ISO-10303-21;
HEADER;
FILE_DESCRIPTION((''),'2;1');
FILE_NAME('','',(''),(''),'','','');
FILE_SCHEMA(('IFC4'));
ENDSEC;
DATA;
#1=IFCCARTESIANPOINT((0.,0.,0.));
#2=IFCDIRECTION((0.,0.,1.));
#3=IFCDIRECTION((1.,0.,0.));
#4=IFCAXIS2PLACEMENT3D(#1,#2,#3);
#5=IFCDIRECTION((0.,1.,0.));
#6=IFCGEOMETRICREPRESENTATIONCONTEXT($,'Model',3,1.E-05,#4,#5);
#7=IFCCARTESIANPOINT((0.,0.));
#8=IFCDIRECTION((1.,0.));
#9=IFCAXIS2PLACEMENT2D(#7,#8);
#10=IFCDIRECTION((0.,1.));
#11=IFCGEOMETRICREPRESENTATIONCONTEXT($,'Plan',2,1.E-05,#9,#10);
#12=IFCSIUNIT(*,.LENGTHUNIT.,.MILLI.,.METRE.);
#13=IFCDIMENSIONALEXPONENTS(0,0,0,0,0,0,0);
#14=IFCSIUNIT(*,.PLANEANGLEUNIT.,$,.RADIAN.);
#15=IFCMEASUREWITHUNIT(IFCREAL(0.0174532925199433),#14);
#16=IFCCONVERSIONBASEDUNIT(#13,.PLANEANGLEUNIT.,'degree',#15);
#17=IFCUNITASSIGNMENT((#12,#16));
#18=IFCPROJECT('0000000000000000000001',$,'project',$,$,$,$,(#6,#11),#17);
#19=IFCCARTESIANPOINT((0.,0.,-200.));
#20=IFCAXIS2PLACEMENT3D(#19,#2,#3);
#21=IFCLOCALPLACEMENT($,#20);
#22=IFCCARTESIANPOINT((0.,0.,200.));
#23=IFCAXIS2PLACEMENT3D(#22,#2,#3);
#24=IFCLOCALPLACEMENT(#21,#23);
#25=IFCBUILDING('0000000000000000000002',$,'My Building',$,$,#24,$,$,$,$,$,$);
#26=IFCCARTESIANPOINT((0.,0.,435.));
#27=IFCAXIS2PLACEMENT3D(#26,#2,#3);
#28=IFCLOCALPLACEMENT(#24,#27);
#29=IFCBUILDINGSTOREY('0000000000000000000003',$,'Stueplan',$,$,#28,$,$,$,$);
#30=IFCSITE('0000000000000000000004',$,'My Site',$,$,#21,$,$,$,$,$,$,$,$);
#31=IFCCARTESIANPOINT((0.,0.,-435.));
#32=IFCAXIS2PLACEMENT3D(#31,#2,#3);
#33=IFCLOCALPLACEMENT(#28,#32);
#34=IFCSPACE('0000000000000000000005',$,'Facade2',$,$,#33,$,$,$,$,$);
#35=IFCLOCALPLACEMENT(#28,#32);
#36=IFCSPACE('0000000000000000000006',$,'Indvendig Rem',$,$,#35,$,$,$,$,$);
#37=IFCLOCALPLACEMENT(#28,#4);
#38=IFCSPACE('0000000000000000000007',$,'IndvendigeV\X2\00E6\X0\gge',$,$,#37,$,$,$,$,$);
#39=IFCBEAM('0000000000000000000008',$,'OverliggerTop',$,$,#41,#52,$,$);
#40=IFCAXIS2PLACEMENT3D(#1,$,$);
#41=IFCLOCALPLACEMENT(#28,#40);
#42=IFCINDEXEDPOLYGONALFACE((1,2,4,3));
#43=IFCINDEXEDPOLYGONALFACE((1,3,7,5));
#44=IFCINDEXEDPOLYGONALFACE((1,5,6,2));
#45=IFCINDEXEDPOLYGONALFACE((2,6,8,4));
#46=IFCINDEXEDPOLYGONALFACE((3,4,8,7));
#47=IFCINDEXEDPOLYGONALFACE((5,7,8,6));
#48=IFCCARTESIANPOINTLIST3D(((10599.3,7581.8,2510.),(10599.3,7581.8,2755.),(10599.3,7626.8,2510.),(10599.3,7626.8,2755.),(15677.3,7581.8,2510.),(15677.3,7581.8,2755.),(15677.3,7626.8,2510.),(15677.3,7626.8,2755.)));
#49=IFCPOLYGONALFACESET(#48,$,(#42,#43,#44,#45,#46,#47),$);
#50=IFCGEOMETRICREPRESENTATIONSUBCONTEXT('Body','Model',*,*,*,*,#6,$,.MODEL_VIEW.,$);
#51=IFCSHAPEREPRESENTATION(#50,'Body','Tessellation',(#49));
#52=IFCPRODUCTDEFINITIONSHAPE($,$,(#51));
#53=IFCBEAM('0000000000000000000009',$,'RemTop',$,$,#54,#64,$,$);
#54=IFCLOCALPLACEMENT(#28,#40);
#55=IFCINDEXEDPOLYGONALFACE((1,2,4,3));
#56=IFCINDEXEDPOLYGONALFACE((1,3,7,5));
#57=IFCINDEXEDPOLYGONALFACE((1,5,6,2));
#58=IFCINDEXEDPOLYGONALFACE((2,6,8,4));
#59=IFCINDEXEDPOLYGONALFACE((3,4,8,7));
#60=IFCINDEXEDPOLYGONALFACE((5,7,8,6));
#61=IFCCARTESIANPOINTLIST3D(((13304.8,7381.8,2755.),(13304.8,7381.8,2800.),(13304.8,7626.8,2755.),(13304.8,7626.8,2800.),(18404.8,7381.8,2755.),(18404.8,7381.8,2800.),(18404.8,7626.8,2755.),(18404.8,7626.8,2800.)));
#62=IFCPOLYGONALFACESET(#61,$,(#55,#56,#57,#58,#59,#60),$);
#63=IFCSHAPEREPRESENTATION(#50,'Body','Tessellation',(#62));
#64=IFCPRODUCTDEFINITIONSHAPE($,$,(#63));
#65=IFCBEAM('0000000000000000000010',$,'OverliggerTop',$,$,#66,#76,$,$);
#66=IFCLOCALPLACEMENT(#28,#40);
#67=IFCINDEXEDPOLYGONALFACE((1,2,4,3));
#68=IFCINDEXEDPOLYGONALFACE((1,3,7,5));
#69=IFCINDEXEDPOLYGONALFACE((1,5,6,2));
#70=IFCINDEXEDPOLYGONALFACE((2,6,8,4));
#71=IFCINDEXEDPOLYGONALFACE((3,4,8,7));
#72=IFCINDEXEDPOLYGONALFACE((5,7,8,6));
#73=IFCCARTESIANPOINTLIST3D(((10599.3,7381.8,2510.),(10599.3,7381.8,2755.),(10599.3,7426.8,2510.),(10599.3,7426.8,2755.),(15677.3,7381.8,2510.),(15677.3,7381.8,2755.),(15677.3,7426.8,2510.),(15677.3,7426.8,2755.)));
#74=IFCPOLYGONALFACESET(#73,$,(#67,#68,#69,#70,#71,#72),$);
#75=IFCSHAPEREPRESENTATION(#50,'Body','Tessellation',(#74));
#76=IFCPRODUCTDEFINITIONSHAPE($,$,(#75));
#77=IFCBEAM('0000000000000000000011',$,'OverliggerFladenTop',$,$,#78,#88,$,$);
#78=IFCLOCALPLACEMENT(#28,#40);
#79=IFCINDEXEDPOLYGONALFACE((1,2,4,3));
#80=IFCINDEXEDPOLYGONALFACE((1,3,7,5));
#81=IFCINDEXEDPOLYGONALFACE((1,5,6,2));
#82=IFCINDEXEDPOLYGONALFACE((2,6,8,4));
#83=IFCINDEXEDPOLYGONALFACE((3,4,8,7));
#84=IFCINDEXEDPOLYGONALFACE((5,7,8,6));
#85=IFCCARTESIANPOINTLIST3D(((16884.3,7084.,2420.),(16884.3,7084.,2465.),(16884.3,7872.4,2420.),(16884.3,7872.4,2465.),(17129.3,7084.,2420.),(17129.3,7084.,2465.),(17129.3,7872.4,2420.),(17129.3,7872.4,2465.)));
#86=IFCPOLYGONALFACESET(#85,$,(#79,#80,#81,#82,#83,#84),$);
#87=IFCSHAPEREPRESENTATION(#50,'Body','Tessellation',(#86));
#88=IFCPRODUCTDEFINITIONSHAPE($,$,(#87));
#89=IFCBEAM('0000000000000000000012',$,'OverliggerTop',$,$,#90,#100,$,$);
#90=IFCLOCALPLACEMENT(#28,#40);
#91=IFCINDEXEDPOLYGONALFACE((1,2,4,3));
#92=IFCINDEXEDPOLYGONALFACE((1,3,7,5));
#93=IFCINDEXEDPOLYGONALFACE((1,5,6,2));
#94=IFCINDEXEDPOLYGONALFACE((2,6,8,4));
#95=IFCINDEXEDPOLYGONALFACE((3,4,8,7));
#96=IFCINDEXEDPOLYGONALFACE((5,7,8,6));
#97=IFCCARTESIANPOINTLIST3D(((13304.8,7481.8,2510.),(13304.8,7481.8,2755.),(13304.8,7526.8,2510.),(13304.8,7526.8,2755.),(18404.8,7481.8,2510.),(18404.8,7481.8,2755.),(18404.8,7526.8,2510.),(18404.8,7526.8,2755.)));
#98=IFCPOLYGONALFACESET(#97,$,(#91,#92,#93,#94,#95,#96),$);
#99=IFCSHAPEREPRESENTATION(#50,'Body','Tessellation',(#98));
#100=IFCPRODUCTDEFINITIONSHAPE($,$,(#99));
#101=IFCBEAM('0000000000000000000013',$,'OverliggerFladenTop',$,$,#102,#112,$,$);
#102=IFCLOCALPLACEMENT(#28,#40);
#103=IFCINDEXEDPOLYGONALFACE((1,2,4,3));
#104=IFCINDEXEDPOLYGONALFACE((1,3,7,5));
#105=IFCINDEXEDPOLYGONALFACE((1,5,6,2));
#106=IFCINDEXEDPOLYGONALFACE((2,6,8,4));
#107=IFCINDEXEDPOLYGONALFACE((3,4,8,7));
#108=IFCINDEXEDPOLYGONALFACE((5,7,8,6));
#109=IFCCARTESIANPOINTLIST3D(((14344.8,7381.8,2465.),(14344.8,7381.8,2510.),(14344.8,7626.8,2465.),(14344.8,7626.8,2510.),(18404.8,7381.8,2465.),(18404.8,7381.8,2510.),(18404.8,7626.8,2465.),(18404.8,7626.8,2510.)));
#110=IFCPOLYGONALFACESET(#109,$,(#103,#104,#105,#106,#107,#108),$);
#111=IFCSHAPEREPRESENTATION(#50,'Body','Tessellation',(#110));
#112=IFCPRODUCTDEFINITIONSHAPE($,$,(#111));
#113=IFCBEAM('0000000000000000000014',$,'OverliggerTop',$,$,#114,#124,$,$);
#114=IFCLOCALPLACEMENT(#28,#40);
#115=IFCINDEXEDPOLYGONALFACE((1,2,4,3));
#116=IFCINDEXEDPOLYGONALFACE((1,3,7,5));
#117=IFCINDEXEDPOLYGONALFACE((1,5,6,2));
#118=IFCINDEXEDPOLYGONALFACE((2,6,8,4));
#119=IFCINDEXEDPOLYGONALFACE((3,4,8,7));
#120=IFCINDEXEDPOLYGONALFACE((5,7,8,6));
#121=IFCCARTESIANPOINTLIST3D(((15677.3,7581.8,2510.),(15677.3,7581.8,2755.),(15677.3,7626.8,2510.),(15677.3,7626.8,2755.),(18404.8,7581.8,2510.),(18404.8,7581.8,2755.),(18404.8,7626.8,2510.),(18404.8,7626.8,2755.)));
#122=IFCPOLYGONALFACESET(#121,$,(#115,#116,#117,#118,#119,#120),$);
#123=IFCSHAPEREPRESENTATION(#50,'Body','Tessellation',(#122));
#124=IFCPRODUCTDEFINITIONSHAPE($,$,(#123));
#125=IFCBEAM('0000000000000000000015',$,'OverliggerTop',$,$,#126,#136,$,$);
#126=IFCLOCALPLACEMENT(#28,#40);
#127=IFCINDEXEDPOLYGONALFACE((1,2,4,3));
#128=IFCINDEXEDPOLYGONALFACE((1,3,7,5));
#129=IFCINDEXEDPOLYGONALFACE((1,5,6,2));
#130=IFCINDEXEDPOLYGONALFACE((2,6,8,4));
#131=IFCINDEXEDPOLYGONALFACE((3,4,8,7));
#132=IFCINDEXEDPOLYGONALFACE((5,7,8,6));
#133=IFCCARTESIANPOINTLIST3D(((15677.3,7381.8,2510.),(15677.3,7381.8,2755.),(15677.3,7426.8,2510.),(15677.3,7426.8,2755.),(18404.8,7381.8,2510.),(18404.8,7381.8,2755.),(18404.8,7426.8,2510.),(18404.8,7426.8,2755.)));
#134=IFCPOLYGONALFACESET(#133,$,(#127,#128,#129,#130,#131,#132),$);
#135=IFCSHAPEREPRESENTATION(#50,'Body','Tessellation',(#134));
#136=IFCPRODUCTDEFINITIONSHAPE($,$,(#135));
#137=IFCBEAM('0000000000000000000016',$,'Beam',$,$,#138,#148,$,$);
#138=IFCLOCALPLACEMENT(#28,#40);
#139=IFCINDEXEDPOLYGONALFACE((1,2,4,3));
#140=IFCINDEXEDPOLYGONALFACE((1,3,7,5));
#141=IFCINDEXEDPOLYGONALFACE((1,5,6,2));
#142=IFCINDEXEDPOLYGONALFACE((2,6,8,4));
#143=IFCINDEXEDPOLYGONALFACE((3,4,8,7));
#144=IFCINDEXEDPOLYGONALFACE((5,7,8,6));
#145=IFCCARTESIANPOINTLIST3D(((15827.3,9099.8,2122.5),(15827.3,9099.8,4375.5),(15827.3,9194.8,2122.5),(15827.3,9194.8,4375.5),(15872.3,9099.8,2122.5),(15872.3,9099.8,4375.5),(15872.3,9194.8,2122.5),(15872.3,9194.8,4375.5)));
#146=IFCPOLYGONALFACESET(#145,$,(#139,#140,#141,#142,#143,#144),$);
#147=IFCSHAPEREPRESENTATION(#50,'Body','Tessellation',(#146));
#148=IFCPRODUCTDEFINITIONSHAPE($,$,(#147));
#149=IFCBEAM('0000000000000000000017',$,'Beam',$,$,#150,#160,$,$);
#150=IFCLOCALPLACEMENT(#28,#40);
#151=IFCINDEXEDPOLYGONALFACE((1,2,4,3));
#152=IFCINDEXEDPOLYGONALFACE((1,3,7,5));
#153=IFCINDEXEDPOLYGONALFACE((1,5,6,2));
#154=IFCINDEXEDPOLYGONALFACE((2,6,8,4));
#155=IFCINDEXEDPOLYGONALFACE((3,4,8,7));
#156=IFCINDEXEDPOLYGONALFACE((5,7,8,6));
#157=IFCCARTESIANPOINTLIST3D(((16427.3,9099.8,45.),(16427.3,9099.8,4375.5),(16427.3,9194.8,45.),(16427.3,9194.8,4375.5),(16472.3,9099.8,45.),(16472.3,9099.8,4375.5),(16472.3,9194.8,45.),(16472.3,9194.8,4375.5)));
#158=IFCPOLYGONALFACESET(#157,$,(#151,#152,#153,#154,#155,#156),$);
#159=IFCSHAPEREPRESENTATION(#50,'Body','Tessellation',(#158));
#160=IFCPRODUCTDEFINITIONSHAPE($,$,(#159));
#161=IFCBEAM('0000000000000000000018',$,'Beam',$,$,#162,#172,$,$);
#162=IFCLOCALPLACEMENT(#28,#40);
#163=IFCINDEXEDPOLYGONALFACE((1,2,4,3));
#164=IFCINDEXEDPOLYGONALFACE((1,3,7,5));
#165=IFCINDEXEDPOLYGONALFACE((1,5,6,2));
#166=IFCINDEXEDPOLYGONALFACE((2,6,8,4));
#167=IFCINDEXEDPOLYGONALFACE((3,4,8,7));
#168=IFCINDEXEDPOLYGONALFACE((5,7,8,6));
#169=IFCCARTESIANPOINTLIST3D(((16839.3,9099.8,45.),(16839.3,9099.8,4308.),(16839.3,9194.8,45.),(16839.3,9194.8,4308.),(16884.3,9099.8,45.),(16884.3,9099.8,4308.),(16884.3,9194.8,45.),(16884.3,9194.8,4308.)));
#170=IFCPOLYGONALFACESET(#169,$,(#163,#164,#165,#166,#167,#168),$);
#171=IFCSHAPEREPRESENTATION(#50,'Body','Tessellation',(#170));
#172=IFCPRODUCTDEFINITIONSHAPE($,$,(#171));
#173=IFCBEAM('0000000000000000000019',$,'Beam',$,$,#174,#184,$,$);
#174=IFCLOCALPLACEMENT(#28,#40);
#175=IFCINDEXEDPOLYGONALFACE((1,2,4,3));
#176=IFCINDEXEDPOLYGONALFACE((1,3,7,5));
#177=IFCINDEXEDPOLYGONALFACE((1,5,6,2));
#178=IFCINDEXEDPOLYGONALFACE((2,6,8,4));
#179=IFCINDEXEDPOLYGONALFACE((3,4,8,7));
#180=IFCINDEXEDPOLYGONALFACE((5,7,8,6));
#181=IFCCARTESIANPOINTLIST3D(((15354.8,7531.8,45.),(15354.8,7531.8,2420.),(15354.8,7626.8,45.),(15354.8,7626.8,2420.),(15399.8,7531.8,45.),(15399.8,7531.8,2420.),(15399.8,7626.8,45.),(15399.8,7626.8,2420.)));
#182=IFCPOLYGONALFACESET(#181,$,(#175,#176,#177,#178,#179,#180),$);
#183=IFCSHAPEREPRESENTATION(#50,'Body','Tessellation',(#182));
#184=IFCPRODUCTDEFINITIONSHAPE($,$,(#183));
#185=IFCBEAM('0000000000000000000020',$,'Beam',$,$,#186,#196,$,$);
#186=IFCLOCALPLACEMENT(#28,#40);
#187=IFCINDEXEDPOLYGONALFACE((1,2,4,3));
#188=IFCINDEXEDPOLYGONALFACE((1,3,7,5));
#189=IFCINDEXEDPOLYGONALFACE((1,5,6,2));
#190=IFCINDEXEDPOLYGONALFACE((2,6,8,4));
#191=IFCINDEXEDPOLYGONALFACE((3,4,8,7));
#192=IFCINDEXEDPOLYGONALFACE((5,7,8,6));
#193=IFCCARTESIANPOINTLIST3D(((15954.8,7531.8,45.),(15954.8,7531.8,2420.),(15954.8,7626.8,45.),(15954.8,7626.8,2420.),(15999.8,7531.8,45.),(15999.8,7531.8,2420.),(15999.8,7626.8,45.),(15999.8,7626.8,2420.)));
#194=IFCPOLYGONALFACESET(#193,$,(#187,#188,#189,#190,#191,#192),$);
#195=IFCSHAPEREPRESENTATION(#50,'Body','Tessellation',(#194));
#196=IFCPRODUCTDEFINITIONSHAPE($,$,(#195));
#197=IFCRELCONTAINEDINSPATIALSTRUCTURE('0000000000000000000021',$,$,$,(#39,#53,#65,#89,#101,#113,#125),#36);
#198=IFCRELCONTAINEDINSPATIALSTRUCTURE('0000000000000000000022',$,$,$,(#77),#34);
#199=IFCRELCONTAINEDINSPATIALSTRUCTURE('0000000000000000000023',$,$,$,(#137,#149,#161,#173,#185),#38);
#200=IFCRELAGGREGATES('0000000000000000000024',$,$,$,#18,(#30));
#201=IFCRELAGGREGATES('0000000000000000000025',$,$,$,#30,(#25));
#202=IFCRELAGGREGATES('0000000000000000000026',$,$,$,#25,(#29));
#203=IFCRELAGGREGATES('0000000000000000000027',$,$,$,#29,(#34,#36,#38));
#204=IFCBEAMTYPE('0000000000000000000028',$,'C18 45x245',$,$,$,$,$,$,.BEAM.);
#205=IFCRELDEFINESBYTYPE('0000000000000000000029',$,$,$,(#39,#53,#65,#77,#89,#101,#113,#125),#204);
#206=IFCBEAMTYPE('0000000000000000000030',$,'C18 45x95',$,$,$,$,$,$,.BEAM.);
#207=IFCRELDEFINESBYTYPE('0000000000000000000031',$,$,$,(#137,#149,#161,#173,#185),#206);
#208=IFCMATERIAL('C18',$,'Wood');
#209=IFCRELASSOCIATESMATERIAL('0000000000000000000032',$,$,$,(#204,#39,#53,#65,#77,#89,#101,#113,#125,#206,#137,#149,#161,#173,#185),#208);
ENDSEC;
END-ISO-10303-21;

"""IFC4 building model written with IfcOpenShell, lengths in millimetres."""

from ifc_helpers import new_model, entity, si_unit, converted_unit, direction, frame, origin_with_axes, origin_2d_with_axis, place, context, subcontext, project, spatial, rectangle, extrude, material, material_profile, profile_set, profile_usage, type_object, element, save


model = new_model("IFC4")

# Units and contexts
model_context = context("Model", 3, precision=1e-05, world=origin_with_axes(), true_north=direction((0.0, 1.0, 0.0)))
plan_context = context("Plan", 2, precision=1e-05, world=origin_2d_with_axis(), true_north=direction((0.0, 1.0)))
body_context_1 = subcontext(model_context, "Body", "Model", "MODEL_VIEW")
ifc_project = project(units=[si_unit("LENGTHUNIT", "METRE", prefix="MILLI"), converted_unit("PLANEANGLEUNIT", "degree", entity("IfcReal", 0.0174532925199433), si_unit("PLANEANGLEUNIT", "RADIAN"), dimensions=[0, 0, 0, 0, 0, 0, 0])], contexts=[model_context, plan_context])

# Site, building, storey, space
site_placement = place(None, frame((0.0, 0.0, -200.0), z_axis=(0.0, 0.0, 1.0), x_axis=(1.0, 0.0, 0.0)))
site = spatial("IfcSite", under=ifc_project, at=site_placement, Name="My Site")
building_placement = place(site_placement, frame((0.0, 0.0, 200.0), z_axis=(0.0, 0.0, 1.0), x_axis=(1.0, 0.0, 0.0)))
building = spatial("IfcBuilding", under=site, at=building_placement, Name="My Building")
storey_placement = place(building_placement, frame((0.0, 0.0, 435.0), z_axis=(0.0, 0.0, 1.0), x_axis=(1.0, 0.0, 0.0)))
storey = spatial("IfcBuildingStorey", under=building, at=storey_placement, Name="Stueplan")
space_1_placement = place(storey_placement, frame((0.0, 0.0, -435.0), z_axis=(0.0, 0.0, 1.0), x_axis=(1.0, 0.0, 0.0)))
space_1 = spatial("IfcSpace", under=storey, at=space_1_placement, Name="Facade2")

# Shared definitions
ifc_material = material(Name="C18", Category="Wood")

# Shared definitions
ifc_material_profile_1 = material_profile(ifc_material, rectangle(XDim=45.0, YDim=245.0), Name="concrete")
ifc_profile_set_1 = profile_set([ifc_material_profile_1], Name="woodStructural")
beam_type_1 = type_object("IfcBeamType", Name="C18 45x245", PredefinedType="BEAM", material=ifc_profile_set_1)

# Shared definitions
space_2_placement = place(storey_placement, frame((0.0, 0.0, -435.0), z_axis=(0.0, 0.0, 1.0), x_axis=(1.0, 0.0, 0.0)))
space_2 = spatial("IfcSpace", under=storey, at=space_2_placement, Name="Indvendig Rem")

# Beams
ifc_profile_usage_1 = profile_usage(ifc_profile_set_1)
beam_1_placement = place(space_2_placement, frame((15677.3, 7604.3, 3067.5), z_axis=(-1.0, 0.0, 0.0), x_axis=(0.0, 1.0, 0.0)))
element("IfcBeam", 1, at=beam_1_placement, inside=space_2, type_object=beam_type_1, material=ifc_profile_usage_1, Name="OverliggerTop", context=body_context_1, shape_type="SweptSolid", body=[
    extrude(rectangle(XDim=45.0, YDim=245.0), origin_with_axes(), (0.0, 0.0, 1.0), 5078.0),
])
ifc_profile_usage_2 = profile_usage(ifc_profile_set_1)
beam_2_placement = place(space_2_placement, frame((18404.8, 7504.3, 3212.5), z_axis=(-1.0, 0.0, 0.0), x_axis=(0.0, 0.0, 1.0)))
element("IfcBeam", 2, at=beam_2_placement, inside=space_2, type_object=beam_type_1, material=ifc_profile_usage_2, Name="RemTop", context=body_context_1, shape_type="SweptSolid", body=[
    extrude(rectangle(XDim=45.0, YDim=245.0), origin_with_axes(), (0.0, 0.0, 1.0), 5100.0),
])
ifc_profile_usage_3 = profile_usage(ifc_profile_set_1)
beam_3_placement = place(space_2_placement, frame((15677.3, 7404.3, 3067.5), z_axis=(-1.0, 0.0, 0.0), x_axis=(0.0, 1.0, 0.0)))
element("IfcBeam", 3, at=beam_3_placement, inside=space_2, type_object=beam_type_1, material=ifc_profile_usage_3, Name="OverliggerTop", context=body_context_1, shape_type="SweptSolid", body=[
    extrude(rectangle(XDim=45.0, YDim=245.0), origin_with_axes(), (0.0, 0.0, 1.0), 5078.0),
])
ifc_profile_usage_4 = profile_usage(ifc_profile_set_1)
beam_4_placement = place(space_1_placement, frame((17006.8, 7084.0, 2877.5), z_axis=(0.0, 1.0, 0.0), x_axis=(0.0, 0.0, 1.0)))
element("IfcBeam", 4, at=beam_4_placement, inside=space_1, type_object=beam_type_1, material=ifc_profile_usage_4, Name="OverliggerFladenTop", context=body_context_1, shape_type="SweptSolid", body=[
    extrude(rectangle(XDim=45.0, YDim=245.0), origin_with_axes(), (0.0, 0.0, 1.0), 788.3),
])
ifc_profile_usage_5 = profile_usage(ifc_profile_set_1)
beam_5_placement = place(space_2_placement, frame((18404.8, 7504.3, 3067.5), z_axis=(-1.0, 0.0, 0.0), x_axis=(0.0, 1.0, 0.0)))
element("IfcBeam", 5, at=beam_5_placement, inside=space_2, type_object=beam_type_1, material=ifc_profile_usage_5, Name="OverliggerTop", context=body_context_1, shape_type="SweptSolid", body=[
    extrude(rectangle(XDim=45.0, YDim=245.0), origin_with_axes(), (0.0, 0.0, 1.0), 5100.0),
])
ifc_profile_usage_6 = profile_usage(ifc_profile_set_1)
beam_6_placement = place(space_2_placement, frame((18404.8, 7504.3, 2922.5), z_axis=(-1.0, 0.0, 0.0), x_axis=(0.0, 0.0, 1.0)))
element("IfcBeam", 6, at=beam_6_placement, inside=space_2, type_object=beam_type_1, material=ifc_profile_usage_6, Name="OverliggerFladenTop", context=body_context_1, shape_type="SweptSolid", body=[
    extrude(rectangle(XDim=45.0, YDim=245.0), origin_with_axes(), (0.0, 0.0, 1.0), 4060.0),
])
ifc_profile_usage_7 = profile_usage(ifc_profile_set_1)
beam_7_placement = place(space_2_placement, frame((18404.8, 7604.3, 3067.5), z_axis=(-1.0, 0.0, 0.0), x_axis=(0.0, 1.0, 0.0)))
element("IfcBeam", 7, at=beam_7_placement, inside=space_2, type_object=beam_type_1, material=ifc_profile_usage_7, Name="OverliggerTop", context=body_context_1, shape_type="SweptSolid", body=[
    extrude(rectangle(XDim=45.0, YDim=245.0), origin_with_axes(), (0.0, 0.0, 1.0), 2727.5),
])
ifc_profile_usage_8 = profile_usage(ifc_profile_set_1)
beam_8_placement = place(space_2_placement, frame((18404.8, 7404.3, 3067.5), z_axis=(-1.0, 0.0, 0.0), x_axis=(0.0, 1.0, 0.0)))
element("IfcBeam", 8, at=beam_8_placement, inside=space_2, type_object=beam_type_1, material=ifc_profile_usage_8, Name="OverliggerTop", context=body_context_1, shape_type="SweptSolid", body=[
    extrude(rectangle(XDim=45.0, YDim=245.0), origin_with_axes(), (0.0, 0.0, 1.0), 2727.5),
])

# Shared definitions
space_3_placement = place(storey_placement, frame((0.0, 0.0, 0.0), z_axis=(0.0, 0.0, 1.0), x_axis=(1.0, 0.0, 0.0)))
space_3 = spatial("IfcSpace", under=storey, at=space_3_placement, Name="IndvendigeVægge")

# Beams
ifc_material_profile_2 = material_profile(ifc_material, rectangle(XDim=45.0, YDim=95.0))
ifc_profile_set_2 = profile_set([ifc_material_profile_2], Name="woodStructural")
ifc_profile_usage_9 = profile_usage(ifc_profile_set_2)
beam_type_2 = type_object("IfcBeamType", Name="C18 45x95", PredefinedType="BEAM", material=ifc_profile_set_2)
beam_9_placement = place(space_3_placement, frame((15849.8, 9147.3, 2122.5), z_axis=(0.0, 0.0, 1.0), x_axis=(-1.0, 0.0, 0.0)))
element("IfcBeam", 9, at=beam_9_placement, inside=space_3, type_object=beam_type_2, material=ifc_profile_usage_9, Name="Beam", context=body_context_1, shape_type="SweptSolid", body=[
    extrude(rectangle(XDim=45.0, YDim=95.0), origin_with_axes(), (0.0, 0.0, 1.0), 2253.0),
])
ifc_profile_usage_10 = profile_usage(ifc_profile_set_2)
beam_10_placement = place(space_3_placement, frame((16449.8, 9147.3, 45.0), z_axis=(0.0, 0.0, 1.0), x_axis=(-1.0, 0.0, 0.0)))
element("IfcBeam", 10, at=beam_10_placement, inside=space_3, type_object=beam_type_2, material=ifc_profile_usage_10, Name="Beam", context=body_context_1, shape_type="SweptSolid", body=[
    extrude(rectangle(XDim=45.0, YDim=95.0), origin_with_axes(), (0.0, 0.0, 1.0), 4330.5),
])
ifc_profile_usage_11 = profile_usage(ifc_profile_set_2)
beam_11_placement = place(space_3_placement, frame((16861.8, 9147.3, 45.0), z_axis=(0.0, 0.0, 1.0), x_axis=(-1.0, 0.0, 0.0)))
element("IfcBeam", 11, at=beam_11_placement, inside=space_3, type_object=beam_type_2, material=ifc_profile_usage_11, Name="Beam", context=body_context_1, shape_type="SweptSolid", body=[
    extrude(rectangle(XDim=45.0, YDim=95.0), origin_with_axes(), (0.0, 0.0, 1.0), 4263.0),
])
ifc_profile_usage_12 = profile_usage(ifc_profile_set_2)
beam_12_placement = place(space_3_placement, frame((15377.3, 7579.3, 45.0), z_axis=(0.0, 0.0, 1.0), x_axis=(1.0, 0.0, 0.0)))
element("IfcBeam", 12, at=beam_12_placement, inside=space_3, type_object=beam_type_2, material=ifc_profile_usage_12, Name="Beam", context=body_context_1, shape_type="SweptSolid", body=[
    extrude(rectangle(XDim=45.0, YDim=95.0), origin_with_axes(), (0.0, 0.0, 1.0), 2375.0),
])
ifc_profile_usage_13 = profile_usage(ifc_profile_set_2)
beam_13_placement = place(space_3_placement, frame((15977.3, 7579.3, 45.0), z_axis=(0.0, 0.0, 1.0), x_axis=(1.0, 0.0, 0.0)))
element("IfcBeam", 13, at=beam_13_placement, inside=space_3, type_object=beam_type_2, material=ifc_profile_usage_13, Name="Beam", context=body_context_1, shape_type="SweptSolid", body=[
    extrude(rectangle(XDim=45.0, YDim=95.0), origin_with_axes(), (0.0, 0.0, 1.0), 2375.0),
])

save(model, "model.ifc")
